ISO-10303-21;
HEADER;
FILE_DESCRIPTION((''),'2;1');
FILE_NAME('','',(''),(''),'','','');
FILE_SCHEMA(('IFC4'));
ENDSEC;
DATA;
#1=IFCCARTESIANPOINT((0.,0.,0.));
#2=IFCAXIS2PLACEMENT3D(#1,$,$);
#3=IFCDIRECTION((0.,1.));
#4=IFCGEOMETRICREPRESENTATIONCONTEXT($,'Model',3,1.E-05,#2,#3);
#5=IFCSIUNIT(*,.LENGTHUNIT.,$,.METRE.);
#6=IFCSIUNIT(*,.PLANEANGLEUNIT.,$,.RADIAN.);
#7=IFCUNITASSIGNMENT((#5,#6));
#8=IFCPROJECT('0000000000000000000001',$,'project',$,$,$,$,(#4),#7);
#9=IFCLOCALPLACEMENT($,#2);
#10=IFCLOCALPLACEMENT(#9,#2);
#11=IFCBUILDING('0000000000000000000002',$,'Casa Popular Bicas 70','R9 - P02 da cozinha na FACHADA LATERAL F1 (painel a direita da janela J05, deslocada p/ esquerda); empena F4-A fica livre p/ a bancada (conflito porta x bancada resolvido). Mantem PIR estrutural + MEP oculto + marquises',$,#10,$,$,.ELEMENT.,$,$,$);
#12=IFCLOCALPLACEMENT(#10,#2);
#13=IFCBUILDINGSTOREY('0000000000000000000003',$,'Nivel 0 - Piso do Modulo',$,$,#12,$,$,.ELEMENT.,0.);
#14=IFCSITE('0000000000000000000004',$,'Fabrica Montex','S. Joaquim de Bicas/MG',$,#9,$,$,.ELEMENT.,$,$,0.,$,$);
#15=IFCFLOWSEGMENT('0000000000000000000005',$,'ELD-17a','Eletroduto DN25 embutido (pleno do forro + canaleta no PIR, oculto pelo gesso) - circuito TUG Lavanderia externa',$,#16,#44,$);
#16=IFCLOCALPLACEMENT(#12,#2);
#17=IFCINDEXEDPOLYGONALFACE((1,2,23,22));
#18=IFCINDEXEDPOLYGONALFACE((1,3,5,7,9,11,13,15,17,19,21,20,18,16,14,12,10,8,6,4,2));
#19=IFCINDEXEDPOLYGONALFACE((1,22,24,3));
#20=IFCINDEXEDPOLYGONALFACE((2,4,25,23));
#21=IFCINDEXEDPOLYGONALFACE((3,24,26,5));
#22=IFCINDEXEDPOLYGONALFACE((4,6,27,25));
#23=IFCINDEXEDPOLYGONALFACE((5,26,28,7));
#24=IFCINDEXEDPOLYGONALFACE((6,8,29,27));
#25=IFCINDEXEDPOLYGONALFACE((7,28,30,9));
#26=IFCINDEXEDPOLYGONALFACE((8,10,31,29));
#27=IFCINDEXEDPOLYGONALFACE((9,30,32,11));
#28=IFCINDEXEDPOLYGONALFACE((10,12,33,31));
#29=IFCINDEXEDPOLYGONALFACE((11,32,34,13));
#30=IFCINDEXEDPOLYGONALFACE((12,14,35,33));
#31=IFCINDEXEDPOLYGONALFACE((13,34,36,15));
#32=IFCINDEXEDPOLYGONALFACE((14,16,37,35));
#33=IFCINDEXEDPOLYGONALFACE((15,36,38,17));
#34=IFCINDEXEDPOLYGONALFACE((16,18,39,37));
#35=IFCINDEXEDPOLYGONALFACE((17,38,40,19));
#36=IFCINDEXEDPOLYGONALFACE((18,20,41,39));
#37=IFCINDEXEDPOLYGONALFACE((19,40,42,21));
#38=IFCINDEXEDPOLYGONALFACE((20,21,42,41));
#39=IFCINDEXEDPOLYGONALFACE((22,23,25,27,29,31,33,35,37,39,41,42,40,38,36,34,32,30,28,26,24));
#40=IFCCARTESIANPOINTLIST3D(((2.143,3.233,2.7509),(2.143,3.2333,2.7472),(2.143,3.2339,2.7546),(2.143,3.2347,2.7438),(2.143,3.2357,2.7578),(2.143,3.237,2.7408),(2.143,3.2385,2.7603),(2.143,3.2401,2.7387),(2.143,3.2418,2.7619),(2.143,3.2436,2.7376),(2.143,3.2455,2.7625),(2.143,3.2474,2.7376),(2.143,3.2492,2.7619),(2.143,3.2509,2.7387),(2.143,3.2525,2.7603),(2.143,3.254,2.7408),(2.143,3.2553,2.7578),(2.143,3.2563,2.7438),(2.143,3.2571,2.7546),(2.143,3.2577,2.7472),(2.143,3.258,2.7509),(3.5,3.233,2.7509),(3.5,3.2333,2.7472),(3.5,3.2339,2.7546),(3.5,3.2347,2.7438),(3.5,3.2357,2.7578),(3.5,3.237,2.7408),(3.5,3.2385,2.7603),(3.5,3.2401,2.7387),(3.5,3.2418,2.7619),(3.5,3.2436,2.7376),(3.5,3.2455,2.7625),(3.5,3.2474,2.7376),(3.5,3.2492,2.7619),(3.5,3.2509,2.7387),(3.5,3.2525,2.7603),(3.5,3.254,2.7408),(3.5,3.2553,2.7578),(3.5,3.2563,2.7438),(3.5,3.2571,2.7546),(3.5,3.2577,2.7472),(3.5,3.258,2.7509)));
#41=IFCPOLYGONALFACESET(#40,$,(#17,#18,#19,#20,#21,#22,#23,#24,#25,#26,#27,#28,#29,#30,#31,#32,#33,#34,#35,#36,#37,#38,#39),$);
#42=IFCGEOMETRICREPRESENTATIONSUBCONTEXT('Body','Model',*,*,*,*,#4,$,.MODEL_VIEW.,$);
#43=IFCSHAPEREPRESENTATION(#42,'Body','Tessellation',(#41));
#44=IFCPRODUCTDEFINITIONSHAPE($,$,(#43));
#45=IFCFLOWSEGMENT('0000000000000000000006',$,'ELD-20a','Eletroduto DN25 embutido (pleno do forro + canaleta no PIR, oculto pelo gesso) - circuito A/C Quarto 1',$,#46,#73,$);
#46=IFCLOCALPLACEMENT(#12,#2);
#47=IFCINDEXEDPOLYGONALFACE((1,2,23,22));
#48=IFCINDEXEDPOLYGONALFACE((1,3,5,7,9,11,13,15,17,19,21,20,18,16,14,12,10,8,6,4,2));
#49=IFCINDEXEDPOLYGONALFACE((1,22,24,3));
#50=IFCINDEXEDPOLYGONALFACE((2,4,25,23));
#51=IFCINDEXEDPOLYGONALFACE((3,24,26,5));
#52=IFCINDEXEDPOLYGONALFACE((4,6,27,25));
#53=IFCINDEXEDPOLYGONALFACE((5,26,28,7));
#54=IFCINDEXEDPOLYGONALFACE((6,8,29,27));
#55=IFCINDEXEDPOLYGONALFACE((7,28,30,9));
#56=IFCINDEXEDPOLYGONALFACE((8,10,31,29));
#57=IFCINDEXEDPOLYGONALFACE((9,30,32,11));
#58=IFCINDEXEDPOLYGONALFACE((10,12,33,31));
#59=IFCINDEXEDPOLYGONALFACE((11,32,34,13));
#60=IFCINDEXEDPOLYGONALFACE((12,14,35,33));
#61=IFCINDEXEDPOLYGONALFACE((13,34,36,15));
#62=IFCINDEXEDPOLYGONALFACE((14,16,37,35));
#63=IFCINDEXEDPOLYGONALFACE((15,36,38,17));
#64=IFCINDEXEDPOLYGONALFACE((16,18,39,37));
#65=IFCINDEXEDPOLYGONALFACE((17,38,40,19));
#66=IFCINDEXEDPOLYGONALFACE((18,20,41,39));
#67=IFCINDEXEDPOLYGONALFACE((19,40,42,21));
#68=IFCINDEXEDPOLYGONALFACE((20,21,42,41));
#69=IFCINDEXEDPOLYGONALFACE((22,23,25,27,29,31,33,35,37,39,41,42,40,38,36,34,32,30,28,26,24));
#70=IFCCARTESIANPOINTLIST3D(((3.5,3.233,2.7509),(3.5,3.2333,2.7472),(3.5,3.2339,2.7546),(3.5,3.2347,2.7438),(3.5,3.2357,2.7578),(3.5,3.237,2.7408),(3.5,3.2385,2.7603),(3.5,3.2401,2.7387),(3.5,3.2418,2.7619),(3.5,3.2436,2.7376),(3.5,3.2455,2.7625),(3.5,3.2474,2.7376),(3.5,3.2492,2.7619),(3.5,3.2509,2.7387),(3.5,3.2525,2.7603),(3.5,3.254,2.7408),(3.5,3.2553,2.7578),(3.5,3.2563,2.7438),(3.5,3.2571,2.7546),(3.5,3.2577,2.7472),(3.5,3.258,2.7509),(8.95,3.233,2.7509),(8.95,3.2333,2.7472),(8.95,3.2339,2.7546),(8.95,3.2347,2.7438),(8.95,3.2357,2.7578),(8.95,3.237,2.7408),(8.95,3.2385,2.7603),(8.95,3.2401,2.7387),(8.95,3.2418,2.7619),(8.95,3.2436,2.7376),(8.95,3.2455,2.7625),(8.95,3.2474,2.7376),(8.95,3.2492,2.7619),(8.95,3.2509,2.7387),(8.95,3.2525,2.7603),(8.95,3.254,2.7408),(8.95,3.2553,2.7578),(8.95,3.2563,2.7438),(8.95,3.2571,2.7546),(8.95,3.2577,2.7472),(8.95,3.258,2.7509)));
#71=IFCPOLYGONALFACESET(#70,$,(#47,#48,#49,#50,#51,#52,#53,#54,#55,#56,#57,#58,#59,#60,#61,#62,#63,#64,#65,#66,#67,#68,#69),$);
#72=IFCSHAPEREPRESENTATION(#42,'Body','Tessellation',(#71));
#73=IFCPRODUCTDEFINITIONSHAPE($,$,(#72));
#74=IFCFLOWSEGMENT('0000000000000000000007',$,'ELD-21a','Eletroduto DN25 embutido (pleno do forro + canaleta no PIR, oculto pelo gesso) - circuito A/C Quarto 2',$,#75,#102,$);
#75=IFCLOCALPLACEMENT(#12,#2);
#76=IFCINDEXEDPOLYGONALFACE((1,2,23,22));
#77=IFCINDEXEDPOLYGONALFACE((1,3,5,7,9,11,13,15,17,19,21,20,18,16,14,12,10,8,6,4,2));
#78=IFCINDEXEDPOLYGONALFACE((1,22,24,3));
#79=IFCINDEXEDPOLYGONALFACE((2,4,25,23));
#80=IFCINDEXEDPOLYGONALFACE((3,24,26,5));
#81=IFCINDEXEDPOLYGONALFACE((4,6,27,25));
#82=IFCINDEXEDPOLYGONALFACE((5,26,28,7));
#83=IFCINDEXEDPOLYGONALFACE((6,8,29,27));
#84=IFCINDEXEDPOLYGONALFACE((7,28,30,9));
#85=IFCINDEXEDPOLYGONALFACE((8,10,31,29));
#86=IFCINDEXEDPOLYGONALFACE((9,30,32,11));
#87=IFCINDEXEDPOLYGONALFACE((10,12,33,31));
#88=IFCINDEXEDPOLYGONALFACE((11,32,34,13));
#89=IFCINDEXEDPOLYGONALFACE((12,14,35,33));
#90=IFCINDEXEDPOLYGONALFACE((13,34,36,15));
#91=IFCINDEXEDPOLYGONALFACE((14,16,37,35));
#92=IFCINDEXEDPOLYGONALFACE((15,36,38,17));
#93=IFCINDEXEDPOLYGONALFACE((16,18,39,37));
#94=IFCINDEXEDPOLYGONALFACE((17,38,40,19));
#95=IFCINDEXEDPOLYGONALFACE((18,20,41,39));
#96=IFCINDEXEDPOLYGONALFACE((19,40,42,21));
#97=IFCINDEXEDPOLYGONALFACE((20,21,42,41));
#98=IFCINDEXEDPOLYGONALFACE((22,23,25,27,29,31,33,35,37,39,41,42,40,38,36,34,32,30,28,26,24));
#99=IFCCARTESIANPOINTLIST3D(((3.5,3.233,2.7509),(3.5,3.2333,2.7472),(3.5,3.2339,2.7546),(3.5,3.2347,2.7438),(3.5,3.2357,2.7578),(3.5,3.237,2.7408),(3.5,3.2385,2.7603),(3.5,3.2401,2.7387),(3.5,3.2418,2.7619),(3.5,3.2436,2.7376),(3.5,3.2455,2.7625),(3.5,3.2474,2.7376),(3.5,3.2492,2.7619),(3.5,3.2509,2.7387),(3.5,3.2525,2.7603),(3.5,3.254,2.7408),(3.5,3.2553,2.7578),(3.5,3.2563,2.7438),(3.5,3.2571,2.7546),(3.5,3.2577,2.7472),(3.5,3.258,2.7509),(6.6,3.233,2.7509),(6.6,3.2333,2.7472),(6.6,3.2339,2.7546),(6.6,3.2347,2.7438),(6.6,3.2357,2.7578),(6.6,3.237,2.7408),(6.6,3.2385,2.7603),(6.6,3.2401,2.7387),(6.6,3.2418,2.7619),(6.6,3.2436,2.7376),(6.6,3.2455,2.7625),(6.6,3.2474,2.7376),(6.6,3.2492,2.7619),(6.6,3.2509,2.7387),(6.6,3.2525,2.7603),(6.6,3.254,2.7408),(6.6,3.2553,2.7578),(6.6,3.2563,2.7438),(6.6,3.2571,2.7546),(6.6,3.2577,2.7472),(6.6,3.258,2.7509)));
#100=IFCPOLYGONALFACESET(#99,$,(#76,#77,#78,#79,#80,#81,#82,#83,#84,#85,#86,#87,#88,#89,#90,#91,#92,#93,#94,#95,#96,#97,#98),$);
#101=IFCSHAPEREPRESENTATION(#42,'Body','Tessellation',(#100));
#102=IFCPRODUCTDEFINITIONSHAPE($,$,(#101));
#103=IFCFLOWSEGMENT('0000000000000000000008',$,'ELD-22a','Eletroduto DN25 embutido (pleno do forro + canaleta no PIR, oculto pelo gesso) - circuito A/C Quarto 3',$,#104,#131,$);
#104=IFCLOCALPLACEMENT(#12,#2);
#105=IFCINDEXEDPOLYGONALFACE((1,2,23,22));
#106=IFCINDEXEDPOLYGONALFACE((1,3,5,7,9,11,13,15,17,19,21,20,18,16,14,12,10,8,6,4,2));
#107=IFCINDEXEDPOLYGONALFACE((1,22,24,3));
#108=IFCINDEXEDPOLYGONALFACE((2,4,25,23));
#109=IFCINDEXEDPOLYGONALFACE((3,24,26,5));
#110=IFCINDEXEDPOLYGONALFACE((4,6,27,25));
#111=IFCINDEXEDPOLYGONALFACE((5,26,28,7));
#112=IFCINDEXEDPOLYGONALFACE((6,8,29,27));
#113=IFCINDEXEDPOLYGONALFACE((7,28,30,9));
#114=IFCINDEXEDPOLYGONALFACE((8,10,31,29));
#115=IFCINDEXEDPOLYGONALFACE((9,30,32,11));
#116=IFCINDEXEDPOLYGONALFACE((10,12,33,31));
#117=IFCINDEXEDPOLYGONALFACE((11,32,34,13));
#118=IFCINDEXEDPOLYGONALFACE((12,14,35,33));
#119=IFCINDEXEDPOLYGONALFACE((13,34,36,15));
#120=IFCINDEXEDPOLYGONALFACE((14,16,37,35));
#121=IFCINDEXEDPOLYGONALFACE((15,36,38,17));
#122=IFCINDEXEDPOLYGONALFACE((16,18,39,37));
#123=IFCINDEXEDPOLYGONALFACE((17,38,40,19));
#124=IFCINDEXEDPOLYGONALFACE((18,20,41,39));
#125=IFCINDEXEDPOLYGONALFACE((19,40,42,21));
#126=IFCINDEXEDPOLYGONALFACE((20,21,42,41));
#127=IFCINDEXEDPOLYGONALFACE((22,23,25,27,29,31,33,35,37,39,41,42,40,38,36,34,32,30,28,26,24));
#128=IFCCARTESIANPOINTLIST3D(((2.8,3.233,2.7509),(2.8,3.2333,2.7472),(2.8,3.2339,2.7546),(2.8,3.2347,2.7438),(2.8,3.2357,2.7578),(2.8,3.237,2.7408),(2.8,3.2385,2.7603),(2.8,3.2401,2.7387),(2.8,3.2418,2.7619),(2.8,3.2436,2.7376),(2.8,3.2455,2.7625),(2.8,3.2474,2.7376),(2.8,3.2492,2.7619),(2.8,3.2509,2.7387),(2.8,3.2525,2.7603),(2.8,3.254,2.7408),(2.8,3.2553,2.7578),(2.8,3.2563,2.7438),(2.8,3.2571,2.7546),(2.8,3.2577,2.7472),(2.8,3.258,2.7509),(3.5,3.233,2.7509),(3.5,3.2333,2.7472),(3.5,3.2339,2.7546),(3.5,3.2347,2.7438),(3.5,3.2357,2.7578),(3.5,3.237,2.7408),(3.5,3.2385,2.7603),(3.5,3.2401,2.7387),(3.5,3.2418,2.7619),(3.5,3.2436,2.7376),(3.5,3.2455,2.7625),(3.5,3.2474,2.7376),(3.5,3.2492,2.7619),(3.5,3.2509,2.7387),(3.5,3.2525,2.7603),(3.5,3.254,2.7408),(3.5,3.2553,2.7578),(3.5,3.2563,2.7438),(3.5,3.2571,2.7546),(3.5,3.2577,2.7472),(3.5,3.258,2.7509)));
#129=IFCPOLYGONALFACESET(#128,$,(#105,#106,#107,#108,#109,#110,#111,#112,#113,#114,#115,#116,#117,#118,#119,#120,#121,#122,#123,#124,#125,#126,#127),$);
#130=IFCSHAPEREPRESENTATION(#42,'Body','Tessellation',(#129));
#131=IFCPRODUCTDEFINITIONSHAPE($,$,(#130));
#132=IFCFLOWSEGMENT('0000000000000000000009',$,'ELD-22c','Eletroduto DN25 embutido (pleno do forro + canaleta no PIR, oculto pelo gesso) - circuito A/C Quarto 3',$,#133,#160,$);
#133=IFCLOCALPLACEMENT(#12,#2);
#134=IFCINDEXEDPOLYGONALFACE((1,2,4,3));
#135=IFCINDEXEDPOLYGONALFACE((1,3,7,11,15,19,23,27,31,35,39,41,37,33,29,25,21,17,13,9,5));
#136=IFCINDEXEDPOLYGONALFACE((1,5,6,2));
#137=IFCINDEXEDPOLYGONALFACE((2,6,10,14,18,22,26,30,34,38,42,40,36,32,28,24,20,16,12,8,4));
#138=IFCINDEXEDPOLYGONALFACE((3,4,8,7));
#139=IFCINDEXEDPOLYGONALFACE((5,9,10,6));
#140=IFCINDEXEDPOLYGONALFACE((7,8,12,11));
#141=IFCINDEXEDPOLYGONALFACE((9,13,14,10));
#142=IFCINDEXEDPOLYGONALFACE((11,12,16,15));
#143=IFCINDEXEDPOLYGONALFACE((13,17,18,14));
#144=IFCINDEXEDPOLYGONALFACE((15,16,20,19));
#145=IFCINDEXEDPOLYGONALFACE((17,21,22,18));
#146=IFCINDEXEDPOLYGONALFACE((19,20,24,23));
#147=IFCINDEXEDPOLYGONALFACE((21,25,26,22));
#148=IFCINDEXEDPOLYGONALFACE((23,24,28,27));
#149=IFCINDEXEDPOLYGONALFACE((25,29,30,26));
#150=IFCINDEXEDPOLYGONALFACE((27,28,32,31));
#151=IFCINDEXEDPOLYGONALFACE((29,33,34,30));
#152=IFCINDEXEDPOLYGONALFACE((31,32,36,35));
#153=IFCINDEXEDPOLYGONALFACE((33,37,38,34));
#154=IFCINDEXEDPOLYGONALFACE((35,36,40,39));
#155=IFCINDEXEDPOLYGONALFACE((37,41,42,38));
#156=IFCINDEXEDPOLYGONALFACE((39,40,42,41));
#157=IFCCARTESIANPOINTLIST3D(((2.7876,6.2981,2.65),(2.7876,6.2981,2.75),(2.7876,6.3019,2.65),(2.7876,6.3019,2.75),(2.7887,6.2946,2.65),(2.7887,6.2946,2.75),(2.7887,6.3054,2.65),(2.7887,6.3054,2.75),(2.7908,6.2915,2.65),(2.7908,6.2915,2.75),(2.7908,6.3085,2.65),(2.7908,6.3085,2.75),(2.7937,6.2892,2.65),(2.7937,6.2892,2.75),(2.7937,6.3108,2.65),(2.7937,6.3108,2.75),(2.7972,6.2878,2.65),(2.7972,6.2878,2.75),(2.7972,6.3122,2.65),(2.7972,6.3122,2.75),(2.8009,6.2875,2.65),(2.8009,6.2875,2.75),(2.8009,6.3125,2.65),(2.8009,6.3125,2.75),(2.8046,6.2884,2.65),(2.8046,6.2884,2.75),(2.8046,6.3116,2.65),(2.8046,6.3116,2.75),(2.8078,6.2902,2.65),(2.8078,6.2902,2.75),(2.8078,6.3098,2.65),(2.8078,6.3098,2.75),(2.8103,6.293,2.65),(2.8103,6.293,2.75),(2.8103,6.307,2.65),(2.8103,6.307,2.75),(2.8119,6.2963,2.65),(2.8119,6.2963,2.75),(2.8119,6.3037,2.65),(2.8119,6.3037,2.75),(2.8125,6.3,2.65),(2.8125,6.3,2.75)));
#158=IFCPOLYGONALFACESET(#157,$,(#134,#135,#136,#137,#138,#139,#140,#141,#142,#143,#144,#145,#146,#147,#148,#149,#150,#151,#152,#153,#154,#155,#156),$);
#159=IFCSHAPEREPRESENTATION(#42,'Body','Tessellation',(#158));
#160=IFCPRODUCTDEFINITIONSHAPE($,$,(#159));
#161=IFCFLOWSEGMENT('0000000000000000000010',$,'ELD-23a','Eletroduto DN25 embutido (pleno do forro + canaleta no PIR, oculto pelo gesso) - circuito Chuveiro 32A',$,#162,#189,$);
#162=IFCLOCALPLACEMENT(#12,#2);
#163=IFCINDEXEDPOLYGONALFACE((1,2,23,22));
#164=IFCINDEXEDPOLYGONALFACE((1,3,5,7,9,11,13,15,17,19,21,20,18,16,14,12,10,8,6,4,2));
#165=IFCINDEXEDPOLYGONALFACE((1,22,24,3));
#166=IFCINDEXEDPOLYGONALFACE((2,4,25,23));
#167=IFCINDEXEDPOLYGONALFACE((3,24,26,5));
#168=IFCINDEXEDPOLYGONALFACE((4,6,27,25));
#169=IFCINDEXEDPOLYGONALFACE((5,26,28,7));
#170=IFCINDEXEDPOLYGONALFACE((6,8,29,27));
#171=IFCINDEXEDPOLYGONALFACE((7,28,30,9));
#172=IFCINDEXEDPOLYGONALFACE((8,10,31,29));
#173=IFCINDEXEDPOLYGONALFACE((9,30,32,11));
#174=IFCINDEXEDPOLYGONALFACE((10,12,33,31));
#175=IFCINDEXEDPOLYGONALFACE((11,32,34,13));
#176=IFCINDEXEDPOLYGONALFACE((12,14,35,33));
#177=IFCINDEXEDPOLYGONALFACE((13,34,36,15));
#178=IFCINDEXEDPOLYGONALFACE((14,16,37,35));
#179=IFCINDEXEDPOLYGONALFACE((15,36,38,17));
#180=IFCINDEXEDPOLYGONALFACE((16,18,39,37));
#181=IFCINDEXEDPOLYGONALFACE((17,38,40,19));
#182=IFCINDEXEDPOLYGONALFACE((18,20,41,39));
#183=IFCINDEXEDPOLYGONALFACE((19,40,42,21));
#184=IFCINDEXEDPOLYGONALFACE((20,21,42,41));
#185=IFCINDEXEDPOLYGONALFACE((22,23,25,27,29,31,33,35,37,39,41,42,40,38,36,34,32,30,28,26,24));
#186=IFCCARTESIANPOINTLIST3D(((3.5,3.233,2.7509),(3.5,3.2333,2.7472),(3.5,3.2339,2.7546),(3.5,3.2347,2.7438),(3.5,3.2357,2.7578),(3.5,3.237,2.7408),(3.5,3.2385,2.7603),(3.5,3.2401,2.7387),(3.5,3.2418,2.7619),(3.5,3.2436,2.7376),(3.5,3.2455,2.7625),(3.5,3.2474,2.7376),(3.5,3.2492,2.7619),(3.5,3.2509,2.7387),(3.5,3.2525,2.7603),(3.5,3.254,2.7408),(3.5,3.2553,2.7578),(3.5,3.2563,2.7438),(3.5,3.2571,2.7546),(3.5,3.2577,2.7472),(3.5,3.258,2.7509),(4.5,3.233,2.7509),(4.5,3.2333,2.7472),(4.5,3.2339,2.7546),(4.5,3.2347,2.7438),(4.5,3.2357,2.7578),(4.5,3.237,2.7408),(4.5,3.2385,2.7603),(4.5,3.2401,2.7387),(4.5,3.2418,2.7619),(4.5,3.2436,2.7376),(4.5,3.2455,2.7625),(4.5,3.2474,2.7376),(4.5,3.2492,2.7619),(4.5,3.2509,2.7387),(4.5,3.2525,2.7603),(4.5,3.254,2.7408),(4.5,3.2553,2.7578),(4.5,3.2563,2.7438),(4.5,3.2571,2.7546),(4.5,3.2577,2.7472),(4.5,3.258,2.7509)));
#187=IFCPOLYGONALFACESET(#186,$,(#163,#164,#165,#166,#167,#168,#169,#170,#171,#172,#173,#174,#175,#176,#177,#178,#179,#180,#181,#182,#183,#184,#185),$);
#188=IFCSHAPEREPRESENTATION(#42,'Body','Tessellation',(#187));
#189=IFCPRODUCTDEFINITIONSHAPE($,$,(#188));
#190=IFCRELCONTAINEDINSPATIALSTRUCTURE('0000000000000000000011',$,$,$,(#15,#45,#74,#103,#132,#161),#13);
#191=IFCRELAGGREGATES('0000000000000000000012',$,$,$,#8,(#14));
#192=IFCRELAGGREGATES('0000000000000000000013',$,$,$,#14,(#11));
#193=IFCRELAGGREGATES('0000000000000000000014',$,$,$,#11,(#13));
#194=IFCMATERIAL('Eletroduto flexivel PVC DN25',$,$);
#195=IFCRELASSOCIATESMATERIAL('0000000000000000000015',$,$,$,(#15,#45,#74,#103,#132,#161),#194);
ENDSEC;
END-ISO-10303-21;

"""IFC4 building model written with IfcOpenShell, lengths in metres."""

from ifc_helpers import new_model, si_unit, direction, frame, origin, origin_2d, place, context, subcontext, project, spatial, circle, extrude, material, element, save


model = new_model("IFC4")

# Units and contexts
model_context = context("Model", 3, precision=1e-05, world=origin(), true_north=direction((0.0, 1.0)))
body_context = subcontext(model_context, "Body", "Model", "MODEL_VIEW")
ifc_project = project(units=[si_unit("LENGTHUNIT", "METRE"), si_unit("PLANEANGLEUNIT", "RADIAN")], contexts=[model_context])

# Site, building, storey
site_placement = place(None, origin())
site = spatial("IfcSite", under=ifc_project, at=site_placement, Name="Fabrica Montex", Description="S. Joaquim de Bicas/MG", CompositionType="ELEMENT", RefElevation=0.0)
building_placement = place(site_placement, origin())
building = spatial("IfcBuilding", under=site, at=building_placement, Name="Casa Popular Bicas 70", Description="R9 - P02 da cozinha na FACHADA LATERAL F1 (painel a direita da janela J05, deslocada p/ esquerda); empena F4-A fica livre p/ a bancada (conflito porta x bancada resolvido). Mantem PIR estrutural + MEP oculto + marquises", CompositionType="ELEMENT")
storey_placement = place(building_placement, origin())
storey = spatial("IfcBuildingStorey", under=building, at=storey_placement, Name="Nivel 0 - Piso do Modulo", CompositionType="ELEMENT", Elevation=0.0)

# Flow segments
ifc_material_1 = material(Name="Eletroduto flexivel PVC DN25")
for number, where, z_axis, x_axis, name in (
    (1, (3.5, 3.2455, 2.75), (-1.0, 0.0, 0.0), (0.0, 0.0, 1.0), "ELD-17a"),
):
    element("IfcFlowSegment", number, at=place(storey_placement, frame(where, z_axis=z_axis, x_axis=x_axis)), inside=storey, material=ifc_material_1, Name=name, Description="Eletroduto DN25 embutido (pleno do forro + canaleta no PIR, oculto pelo gesso) - circuito TUG Lavanderia externa", context=body_context, shape_type="SweptSolid", body=[
        extrude(circle(Radius=0.0125, at=origin_2d()), origin(), (0.0, 0.0, 1.0), 1.357),
    ])
flow_segment_1_placement = place(storey_placement, frame((3.5, 3.2455, 2.75), z_axis=(1.0, 0.0, 0.0), x_axis=(0.0, 0.0, 1.0)))
element("IfcFlowSegment", 2, at=flow_segment_1_placement, inside=storey, material=ifc_material_1, Name="ELD-20a", Description="Eletroduto DN25 embutido (pleno do forro + canaleta no PIR, oculto pelo gesso) - circuito A/C Quarto 1", context=body_context, shape_type="SweptSolid", body=[
    extrude(circle(Radius=0.0125, at=origin_2d()), origin(), (0.0, 0.0, 1.0), 5.45),
])
flow_segment_2_placement = place(storey_placement, frame((3.5, 3.2455, 2.75), z_axis=(1.0, 0.0, 0.0), x_axis=(0.0, 0.0, 1.0)))
element("IfcFlowSegment", 3, at=flow_segment_2_placement, inside=storey, material=ifc_material_1, Name="ELD-21a", Description="Eletroduto DN25 embutido (pleno do forro + canaleta no PIR, oculto pelo gesso) - circuito A/C Quarto 2", context=body_context, shape_type="SweptSolid", body=[
    extrude(circle(Radius=0.0125, at=origin_2d()), origin(), (0.0, 0.0, 1.0), 3.1),
])
flow_segment_3_placement = place(storey_placement, frame((3.5, 3.2455, 2.75), z_axis=(-1.0, 0.0, 0.0), x_axis=(0.0, 0.0, 1.0)))
element("IfcFlowSegment", 4, at=flow_segment_3_placement, inside=storey, material=ifc_material_1, Name="ELD-22a", Description="Eletroduto DN25 embutido (pleno do forro + canaleta no PIR, oculto pelo gesso) - circuito A/C Quarto 3", context=body_context, shape_type="SweptSolid", body=[
    extrude(circle(Radius=0.0125, at=origin_2d()), origin(), (0.0, 0.0, 1.0), 0.7),
])
flow_segment_4_placement = place(storey_placement, frame((2.8, 6.3, 2.75), z_axis=(0.0, 0.0, -1.0), x_axis=(1.0, 0.0, 0.0)))
element("IfcFlowSegment", 5, at=flow_segment_4_placement, inside=storey, material=ifc_material_1, Name="ELD-22c", Description="Eletroduto DN25 embutido (pleno do forro + canaleta no PIR, oculto pelo gesso) - circuito A/C Quarto 3", context=body_context, shape_type="SweptSolid", body=[
    extrude(circle(Radius=0.0125, at=origin_2d()), origin(), (0.0, 0.0, 1.0), 0.1),
])
flow_segment_5_placement = place(storey_placement, frame((3.5, 3.2455, 2.75), z_axis=(1.0, 0.0, 0.0), x_axis=(0.0, 0.0, 1.0)))
element("IfcFlowSegment", 6, at=flow_segment_5_placement, inside=storey, material=ifc_material_1, Name="ELD-23a", Description="Eletroduto DN25 embutido (pleno do forro + canaleta no PIR, oculto pelo gesso) - circuito Chuveiro 32A", context=body_context, shape_type="SweptSolid", body=[
    extrude(circle(Radius=0.0125, at=origin_2d()), origin(), (0.0, 0.0, 1.0), 1.0),
])

save(model, "model.ifc")
